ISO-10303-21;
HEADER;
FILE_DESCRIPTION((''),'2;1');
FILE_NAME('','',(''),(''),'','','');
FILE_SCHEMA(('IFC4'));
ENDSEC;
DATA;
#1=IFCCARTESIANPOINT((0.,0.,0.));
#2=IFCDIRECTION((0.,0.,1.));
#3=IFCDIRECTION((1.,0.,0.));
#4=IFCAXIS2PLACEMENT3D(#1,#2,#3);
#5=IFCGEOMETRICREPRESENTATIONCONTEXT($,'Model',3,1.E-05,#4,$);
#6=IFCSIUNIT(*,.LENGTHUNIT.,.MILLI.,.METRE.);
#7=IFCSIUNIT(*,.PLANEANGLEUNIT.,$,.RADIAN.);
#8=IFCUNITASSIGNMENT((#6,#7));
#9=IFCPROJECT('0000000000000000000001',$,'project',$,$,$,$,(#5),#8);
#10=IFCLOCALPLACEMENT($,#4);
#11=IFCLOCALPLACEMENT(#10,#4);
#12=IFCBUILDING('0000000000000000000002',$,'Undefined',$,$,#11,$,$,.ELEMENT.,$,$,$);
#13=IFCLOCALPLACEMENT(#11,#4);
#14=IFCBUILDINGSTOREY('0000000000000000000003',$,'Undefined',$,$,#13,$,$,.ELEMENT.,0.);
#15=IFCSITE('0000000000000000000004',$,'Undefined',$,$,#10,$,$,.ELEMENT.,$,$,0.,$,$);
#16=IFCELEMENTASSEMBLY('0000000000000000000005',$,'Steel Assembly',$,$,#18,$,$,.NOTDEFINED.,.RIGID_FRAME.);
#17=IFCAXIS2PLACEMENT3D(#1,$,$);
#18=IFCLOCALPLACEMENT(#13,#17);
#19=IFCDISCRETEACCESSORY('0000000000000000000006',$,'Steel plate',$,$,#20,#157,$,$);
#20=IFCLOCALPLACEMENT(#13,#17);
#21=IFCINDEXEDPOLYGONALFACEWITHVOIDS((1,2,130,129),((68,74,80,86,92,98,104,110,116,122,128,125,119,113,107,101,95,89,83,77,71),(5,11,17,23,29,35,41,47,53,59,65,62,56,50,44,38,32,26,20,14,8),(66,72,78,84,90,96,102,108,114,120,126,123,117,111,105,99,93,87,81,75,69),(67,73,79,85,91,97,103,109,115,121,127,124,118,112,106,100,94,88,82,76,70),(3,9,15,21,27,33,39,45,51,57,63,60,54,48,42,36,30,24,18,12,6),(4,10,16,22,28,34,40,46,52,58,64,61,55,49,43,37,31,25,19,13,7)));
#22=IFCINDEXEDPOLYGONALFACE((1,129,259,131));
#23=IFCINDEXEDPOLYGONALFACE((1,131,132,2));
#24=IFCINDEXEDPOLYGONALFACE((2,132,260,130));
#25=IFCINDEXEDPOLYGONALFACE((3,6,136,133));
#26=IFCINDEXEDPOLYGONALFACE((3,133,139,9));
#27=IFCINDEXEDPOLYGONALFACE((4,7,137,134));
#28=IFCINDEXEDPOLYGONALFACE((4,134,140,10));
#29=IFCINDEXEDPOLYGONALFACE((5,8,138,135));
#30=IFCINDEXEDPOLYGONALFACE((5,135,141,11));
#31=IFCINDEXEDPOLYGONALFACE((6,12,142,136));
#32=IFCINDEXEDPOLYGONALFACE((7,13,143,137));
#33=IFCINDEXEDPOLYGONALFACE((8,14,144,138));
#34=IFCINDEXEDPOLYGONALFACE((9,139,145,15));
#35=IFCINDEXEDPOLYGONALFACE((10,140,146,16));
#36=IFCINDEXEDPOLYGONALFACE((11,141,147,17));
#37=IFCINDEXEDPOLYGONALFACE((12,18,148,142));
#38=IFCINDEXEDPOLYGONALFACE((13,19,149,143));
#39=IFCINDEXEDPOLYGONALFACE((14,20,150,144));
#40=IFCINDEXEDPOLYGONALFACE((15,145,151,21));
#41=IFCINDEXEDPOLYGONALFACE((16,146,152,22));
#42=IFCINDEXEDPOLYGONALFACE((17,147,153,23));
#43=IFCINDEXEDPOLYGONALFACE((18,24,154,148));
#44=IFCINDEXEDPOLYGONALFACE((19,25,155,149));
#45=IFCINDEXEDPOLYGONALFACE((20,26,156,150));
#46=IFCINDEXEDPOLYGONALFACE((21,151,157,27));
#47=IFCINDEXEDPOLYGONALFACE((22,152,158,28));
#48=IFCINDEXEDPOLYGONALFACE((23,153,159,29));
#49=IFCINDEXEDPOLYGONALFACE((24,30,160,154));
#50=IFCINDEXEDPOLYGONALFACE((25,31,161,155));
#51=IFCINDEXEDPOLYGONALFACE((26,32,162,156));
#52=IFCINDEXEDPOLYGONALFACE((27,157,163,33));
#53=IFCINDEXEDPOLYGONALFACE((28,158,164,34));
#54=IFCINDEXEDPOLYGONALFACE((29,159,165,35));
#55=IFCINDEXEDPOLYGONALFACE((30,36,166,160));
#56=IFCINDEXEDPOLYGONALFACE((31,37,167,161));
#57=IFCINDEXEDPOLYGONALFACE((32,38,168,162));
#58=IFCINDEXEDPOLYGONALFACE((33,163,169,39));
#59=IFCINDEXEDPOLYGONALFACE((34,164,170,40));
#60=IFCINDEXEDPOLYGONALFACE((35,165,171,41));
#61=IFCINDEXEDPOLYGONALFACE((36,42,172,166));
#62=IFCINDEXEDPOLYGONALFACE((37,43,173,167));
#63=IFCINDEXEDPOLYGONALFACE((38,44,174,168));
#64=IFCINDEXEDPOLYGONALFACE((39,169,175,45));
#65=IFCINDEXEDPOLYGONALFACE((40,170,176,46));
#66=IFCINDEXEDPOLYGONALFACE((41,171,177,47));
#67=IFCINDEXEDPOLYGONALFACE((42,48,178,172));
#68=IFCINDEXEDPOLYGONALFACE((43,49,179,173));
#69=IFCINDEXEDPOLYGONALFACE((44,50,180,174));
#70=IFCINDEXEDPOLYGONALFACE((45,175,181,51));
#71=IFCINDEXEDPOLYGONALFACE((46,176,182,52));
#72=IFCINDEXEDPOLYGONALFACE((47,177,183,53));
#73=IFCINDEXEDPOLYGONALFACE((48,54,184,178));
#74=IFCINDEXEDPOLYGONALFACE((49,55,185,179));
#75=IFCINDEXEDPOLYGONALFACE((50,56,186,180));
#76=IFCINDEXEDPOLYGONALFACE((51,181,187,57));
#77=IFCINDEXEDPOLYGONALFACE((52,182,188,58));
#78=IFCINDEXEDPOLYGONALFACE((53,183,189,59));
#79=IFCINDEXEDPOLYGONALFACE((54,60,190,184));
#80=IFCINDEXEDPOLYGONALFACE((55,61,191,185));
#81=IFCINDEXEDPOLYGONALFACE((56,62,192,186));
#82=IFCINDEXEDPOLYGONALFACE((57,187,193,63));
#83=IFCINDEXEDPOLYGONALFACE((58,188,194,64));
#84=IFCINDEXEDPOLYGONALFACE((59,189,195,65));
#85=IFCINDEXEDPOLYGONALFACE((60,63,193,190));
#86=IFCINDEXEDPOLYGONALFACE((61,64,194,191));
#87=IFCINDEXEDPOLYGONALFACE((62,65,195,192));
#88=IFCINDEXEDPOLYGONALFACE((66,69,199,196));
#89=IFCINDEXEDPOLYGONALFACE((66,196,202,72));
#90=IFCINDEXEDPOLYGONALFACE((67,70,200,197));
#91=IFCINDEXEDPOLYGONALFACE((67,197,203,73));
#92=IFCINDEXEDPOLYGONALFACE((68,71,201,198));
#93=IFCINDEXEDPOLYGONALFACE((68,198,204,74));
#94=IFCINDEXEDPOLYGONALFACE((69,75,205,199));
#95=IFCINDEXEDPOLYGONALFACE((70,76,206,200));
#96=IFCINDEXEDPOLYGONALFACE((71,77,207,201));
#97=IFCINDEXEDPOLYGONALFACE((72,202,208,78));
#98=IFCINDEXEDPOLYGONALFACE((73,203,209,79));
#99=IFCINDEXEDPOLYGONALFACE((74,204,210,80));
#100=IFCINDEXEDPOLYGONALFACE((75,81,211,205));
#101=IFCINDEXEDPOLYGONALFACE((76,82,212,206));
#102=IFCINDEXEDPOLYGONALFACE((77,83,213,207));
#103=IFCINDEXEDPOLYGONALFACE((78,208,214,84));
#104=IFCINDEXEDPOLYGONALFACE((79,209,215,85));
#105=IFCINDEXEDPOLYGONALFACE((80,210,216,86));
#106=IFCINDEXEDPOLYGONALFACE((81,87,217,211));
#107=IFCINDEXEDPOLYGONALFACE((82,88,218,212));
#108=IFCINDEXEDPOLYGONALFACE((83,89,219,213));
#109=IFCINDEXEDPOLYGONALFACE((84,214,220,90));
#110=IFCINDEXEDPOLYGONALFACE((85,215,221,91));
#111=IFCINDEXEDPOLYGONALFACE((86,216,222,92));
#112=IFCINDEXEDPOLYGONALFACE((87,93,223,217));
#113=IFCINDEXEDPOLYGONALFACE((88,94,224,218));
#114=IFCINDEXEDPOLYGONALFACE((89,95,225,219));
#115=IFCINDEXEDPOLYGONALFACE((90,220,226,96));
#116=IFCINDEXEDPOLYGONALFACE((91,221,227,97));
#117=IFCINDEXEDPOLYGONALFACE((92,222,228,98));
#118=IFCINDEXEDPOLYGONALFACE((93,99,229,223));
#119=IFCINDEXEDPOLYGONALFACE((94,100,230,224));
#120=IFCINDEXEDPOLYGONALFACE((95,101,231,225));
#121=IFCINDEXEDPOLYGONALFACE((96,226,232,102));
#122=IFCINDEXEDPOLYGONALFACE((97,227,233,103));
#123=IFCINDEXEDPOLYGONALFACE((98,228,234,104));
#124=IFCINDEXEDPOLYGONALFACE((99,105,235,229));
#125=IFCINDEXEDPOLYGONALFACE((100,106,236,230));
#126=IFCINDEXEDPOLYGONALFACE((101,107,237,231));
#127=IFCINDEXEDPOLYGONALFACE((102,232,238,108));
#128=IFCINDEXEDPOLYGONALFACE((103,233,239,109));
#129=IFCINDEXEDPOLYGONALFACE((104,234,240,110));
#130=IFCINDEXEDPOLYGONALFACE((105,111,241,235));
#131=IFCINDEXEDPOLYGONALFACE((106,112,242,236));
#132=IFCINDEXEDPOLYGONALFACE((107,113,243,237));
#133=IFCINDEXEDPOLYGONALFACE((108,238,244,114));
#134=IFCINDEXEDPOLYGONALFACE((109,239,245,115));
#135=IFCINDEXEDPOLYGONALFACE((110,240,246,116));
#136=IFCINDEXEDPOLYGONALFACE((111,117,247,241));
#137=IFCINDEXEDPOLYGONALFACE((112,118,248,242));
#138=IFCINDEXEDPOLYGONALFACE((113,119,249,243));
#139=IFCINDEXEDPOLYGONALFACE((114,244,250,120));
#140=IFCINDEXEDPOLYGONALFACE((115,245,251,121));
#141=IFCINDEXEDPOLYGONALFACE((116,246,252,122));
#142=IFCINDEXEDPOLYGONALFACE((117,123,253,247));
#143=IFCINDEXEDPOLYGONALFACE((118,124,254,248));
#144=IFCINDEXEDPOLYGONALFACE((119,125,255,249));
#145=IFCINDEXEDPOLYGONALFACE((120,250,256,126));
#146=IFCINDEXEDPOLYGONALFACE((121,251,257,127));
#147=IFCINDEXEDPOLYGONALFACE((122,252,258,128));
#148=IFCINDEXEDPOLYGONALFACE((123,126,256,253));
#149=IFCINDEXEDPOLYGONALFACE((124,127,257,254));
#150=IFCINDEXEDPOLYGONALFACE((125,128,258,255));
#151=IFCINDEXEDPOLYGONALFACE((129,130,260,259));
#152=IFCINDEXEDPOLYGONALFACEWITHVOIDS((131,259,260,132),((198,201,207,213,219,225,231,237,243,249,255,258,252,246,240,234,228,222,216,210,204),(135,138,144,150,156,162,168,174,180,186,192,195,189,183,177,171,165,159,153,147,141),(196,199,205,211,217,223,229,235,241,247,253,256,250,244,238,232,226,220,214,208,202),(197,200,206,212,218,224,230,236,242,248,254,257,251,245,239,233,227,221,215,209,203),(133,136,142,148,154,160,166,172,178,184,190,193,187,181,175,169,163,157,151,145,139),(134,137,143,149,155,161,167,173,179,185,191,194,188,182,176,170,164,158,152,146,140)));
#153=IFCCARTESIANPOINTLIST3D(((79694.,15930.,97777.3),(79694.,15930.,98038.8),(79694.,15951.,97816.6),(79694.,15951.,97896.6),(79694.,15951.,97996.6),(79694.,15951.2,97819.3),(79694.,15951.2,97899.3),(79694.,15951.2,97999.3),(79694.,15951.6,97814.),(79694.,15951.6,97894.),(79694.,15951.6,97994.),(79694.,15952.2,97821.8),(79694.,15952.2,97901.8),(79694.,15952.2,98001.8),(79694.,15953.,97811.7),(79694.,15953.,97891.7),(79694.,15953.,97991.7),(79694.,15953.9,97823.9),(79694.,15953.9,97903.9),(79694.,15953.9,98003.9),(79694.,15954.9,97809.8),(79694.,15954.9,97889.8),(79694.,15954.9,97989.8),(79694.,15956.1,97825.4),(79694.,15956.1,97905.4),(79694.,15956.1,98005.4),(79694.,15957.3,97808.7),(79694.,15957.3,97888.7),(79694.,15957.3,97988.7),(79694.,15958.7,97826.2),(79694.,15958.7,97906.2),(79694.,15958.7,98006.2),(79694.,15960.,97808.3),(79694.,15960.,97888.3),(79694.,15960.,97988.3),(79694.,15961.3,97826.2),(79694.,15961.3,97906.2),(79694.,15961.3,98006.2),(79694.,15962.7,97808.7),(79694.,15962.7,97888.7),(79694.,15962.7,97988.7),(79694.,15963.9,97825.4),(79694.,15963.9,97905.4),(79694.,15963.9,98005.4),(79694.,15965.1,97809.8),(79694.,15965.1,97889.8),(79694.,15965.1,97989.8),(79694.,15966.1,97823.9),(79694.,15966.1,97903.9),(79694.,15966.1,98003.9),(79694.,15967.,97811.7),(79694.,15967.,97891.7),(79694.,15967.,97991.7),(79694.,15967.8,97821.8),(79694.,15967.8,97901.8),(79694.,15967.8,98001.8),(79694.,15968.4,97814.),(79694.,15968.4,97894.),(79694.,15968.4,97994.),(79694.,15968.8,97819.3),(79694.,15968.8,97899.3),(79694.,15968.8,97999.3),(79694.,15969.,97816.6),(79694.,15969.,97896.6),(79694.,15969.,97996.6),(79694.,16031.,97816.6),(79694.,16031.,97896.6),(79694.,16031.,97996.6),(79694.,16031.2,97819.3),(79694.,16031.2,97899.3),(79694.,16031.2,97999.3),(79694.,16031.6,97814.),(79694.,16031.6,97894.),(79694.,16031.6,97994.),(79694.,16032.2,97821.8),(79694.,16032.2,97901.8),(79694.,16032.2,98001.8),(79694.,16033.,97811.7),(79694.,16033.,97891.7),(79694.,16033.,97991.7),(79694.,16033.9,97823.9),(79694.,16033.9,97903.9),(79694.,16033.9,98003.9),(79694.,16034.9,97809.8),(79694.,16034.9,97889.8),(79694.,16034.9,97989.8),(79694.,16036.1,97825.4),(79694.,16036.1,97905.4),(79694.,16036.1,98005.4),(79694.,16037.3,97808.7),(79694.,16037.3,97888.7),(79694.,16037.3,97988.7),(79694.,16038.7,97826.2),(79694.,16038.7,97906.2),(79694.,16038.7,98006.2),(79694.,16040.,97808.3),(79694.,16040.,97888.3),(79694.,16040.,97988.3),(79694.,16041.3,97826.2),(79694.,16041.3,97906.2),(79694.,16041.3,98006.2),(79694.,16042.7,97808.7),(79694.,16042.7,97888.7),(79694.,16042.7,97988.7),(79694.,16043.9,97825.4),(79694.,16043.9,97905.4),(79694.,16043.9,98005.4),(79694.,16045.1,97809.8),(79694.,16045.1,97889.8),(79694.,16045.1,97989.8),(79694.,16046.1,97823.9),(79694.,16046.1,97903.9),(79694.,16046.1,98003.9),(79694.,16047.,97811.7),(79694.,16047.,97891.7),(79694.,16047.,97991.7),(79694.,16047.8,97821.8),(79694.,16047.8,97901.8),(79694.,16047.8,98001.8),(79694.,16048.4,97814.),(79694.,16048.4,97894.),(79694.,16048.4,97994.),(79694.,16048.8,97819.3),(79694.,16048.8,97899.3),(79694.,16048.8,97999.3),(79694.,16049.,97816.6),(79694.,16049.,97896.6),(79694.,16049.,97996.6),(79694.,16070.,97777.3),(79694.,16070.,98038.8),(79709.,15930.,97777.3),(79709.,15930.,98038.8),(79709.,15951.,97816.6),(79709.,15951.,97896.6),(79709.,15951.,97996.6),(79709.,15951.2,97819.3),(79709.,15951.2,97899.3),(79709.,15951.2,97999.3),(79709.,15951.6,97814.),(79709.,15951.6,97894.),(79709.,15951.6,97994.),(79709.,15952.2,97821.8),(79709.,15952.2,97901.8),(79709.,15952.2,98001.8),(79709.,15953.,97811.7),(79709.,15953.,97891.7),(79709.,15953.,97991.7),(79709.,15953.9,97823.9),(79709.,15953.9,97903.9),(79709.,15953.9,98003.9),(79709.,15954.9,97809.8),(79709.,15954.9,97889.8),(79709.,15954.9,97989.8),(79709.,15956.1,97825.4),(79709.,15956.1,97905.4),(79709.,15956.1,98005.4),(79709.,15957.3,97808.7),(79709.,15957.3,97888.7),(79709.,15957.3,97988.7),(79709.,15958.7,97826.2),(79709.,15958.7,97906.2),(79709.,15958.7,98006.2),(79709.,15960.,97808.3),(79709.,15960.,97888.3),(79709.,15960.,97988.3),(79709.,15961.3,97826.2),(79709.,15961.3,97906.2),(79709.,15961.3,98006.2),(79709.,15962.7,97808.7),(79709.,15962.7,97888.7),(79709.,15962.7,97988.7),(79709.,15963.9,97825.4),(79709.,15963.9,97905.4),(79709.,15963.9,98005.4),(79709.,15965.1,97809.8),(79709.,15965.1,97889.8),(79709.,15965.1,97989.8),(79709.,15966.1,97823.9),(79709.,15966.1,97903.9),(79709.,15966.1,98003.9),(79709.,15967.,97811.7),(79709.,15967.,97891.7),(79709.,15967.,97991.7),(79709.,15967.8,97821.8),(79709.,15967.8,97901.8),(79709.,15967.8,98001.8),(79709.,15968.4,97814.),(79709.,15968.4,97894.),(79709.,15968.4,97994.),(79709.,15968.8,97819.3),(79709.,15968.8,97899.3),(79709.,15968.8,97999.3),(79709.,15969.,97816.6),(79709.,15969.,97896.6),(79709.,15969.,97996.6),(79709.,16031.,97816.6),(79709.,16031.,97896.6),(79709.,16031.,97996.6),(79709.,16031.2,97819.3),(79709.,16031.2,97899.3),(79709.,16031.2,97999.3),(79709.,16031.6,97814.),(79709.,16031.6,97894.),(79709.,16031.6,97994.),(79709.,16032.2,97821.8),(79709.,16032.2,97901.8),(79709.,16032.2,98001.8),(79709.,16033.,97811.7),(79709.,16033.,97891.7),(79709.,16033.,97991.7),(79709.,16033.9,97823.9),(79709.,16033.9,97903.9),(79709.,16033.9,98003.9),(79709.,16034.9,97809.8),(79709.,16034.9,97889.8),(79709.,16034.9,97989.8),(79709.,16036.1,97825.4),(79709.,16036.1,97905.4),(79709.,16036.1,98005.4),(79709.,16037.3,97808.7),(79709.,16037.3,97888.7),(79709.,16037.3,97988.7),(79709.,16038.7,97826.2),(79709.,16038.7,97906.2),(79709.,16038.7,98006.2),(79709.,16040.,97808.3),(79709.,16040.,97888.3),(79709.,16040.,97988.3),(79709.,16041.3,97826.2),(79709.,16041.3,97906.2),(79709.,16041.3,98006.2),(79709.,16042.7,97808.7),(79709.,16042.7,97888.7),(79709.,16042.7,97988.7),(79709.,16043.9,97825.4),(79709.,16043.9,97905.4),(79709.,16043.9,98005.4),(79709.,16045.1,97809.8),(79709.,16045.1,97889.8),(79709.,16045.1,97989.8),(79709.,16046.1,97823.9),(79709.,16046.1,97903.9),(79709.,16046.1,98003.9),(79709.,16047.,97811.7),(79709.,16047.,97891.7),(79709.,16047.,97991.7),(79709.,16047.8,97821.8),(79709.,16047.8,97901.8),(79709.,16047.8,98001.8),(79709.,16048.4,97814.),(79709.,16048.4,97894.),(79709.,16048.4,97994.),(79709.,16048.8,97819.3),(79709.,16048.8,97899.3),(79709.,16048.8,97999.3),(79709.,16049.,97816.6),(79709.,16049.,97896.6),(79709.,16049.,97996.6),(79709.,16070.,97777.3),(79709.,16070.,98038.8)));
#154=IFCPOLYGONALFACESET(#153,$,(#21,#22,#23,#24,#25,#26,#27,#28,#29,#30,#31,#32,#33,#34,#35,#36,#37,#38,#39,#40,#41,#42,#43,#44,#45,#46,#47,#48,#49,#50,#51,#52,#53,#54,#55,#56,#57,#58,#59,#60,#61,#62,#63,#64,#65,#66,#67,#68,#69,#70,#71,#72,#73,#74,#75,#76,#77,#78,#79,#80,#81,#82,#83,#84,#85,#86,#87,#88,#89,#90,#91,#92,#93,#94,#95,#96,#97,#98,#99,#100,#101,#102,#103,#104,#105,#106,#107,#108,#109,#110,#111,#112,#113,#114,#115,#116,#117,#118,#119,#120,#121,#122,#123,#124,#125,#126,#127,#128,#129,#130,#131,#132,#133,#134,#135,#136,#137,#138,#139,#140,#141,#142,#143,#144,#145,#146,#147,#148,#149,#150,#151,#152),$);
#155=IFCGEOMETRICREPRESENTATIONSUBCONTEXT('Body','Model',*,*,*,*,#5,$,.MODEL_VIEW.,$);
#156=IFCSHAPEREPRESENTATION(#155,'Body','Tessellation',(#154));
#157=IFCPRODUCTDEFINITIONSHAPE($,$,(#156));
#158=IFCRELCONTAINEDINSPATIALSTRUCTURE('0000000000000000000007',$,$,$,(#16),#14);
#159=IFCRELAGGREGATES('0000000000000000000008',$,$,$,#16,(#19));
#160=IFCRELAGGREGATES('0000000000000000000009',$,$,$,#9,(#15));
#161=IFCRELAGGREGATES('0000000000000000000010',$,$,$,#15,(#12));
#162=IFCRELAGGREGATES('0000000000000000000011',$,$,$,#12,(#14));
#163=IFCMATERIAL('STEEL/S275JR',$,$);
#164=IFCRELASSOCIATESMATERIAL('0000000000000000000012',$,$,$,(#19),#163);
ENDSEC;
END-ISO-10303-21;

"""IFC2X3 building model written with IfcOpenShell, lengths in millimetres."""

from ifc_helpers import new_model, si_unit, frame, origin_with_axes, origin_2d_with_axis, place, context, subcontext, project, spatial, polyline, circle, outline, extrude, source, transform, mapped, material, element, aggregate, save


model = new_model("IFC2X3")

# Units and contexts
model_context = context("Model", 3, precision=1e-05, world=origin_with_axes())
body_context = subcontext(model_context, "Body", "Model", "MODEL_VIEW")
ifc_project = project(units=[si_unit("LENGTHUNIT", "METRE", prefix="MILLI"), si_unit("PLANEANGLEUNIT", "RADIAN")], contexts=[model_context])

# Site, building, storey
site_placement = place(None, origin_with_axes())
site = spatial("IfcSite", under=ifc_project, at=site_placement, Name="Undefined", CompositionType="ELEMENT", RefElevation=0.0)
building_placement = place(site_placement, origin_with_axes())
building = spatial("IfcBuilding", under=site, at=building_placement, Name="Undefined", CompositionType="ELEMENT")
storey_placement = place(building_placement, origin_with_axes())
storey = spatial("IfcBuildingStorey", under=building, at=storey_placement, Name="Undefined", CompositionType="ELEMENT", Elevation=0.0)

# Shared definitions
ifc_material_1 = material(Name="STEEL/S275JR")

# Element assembly, discrete accessory, opening
assembly_1_placement = place(storey_placement, origin_with_axes())
assembly_1 = element("IfcElementAssembly", 1, at=assembly_1_placement, inside=storey, Name="Steel Assembly", AssemblyPlace="NOTDEFINED", PredefinedType="RIGID_FRAME")
discrete_accessory_1_placement = place(assembly_1_placement, frame((79701.5, 15930.0, 98038.8), z_axis=(-1.0, 0.0, 0.0), x_axis=(0.0, 1.0, 0.0)))
discrete_accessory_1 = element("IfcDiscreteAccessory", 2, at=discrete_accessory_1_placement, material=ifc_material_1, Name="Steel plate", context=body_context, shape_type="SweptSolid", body=[
    extrude(outline(polyline([(0.0, 0.0), (140.0, 0.0), (140.0, 261.5), (0.0, 261.5), (0.0, 0.0)])), frame((0.0, 0.0, -7.5), z_axis=(0.0, 0.0, 1.0), x_axis=(1.0, 0.0, 0.0)), (0.0, 0.0, 1.0), 15.0),
])
shared_shape_1 = source(origin_with_axes(), body_context, "Body", "SweptSolid", [
    extrude(circle(Radius=9.0, at=origin_2d_with_axis()), frame((0.0, -20.1, 0.0), z_axis=(0.0, 1.0, 0.0), x_axis=(1.0, 0.0, 0.0)), (0.0, 0.0, 1.0), 35.3),
])
opening_1_placement = place(assembly_1_placement, frame((79714.0, 16000.0, 97997.3), z_axis=(0.0, -1.0, 0.0), x_axis=(0.0, 0.0, -1.0)))
element("IfcOpeningElement", 3, at=opening_1_placement, cuts=discrete_accessory_1, ObjectType="Opening", context=body_context, shape_type="MappedRepresentation", body=[
    mapped(shared_shape_1, transform((0.0, 0.0, -40.0))),
    mapped(shared_shape_1, transform((100.0, 0.0, -40.0))),
    mapped(shared_shape_1, transform((180.0, 0.0, -40.0))),
    mapped(shared_shape_1, transform((0.0, 0.0, 40.0))),
    mapped(shared_shape_1, transform((100.0, 0.0, 40.0))),
    mapped(shared_shape_1, transform((180.0, 0.0, 40.0))),
])

aggregate(assembly_1, [discrete_accessory_1])

save(model, "model.ifc")
